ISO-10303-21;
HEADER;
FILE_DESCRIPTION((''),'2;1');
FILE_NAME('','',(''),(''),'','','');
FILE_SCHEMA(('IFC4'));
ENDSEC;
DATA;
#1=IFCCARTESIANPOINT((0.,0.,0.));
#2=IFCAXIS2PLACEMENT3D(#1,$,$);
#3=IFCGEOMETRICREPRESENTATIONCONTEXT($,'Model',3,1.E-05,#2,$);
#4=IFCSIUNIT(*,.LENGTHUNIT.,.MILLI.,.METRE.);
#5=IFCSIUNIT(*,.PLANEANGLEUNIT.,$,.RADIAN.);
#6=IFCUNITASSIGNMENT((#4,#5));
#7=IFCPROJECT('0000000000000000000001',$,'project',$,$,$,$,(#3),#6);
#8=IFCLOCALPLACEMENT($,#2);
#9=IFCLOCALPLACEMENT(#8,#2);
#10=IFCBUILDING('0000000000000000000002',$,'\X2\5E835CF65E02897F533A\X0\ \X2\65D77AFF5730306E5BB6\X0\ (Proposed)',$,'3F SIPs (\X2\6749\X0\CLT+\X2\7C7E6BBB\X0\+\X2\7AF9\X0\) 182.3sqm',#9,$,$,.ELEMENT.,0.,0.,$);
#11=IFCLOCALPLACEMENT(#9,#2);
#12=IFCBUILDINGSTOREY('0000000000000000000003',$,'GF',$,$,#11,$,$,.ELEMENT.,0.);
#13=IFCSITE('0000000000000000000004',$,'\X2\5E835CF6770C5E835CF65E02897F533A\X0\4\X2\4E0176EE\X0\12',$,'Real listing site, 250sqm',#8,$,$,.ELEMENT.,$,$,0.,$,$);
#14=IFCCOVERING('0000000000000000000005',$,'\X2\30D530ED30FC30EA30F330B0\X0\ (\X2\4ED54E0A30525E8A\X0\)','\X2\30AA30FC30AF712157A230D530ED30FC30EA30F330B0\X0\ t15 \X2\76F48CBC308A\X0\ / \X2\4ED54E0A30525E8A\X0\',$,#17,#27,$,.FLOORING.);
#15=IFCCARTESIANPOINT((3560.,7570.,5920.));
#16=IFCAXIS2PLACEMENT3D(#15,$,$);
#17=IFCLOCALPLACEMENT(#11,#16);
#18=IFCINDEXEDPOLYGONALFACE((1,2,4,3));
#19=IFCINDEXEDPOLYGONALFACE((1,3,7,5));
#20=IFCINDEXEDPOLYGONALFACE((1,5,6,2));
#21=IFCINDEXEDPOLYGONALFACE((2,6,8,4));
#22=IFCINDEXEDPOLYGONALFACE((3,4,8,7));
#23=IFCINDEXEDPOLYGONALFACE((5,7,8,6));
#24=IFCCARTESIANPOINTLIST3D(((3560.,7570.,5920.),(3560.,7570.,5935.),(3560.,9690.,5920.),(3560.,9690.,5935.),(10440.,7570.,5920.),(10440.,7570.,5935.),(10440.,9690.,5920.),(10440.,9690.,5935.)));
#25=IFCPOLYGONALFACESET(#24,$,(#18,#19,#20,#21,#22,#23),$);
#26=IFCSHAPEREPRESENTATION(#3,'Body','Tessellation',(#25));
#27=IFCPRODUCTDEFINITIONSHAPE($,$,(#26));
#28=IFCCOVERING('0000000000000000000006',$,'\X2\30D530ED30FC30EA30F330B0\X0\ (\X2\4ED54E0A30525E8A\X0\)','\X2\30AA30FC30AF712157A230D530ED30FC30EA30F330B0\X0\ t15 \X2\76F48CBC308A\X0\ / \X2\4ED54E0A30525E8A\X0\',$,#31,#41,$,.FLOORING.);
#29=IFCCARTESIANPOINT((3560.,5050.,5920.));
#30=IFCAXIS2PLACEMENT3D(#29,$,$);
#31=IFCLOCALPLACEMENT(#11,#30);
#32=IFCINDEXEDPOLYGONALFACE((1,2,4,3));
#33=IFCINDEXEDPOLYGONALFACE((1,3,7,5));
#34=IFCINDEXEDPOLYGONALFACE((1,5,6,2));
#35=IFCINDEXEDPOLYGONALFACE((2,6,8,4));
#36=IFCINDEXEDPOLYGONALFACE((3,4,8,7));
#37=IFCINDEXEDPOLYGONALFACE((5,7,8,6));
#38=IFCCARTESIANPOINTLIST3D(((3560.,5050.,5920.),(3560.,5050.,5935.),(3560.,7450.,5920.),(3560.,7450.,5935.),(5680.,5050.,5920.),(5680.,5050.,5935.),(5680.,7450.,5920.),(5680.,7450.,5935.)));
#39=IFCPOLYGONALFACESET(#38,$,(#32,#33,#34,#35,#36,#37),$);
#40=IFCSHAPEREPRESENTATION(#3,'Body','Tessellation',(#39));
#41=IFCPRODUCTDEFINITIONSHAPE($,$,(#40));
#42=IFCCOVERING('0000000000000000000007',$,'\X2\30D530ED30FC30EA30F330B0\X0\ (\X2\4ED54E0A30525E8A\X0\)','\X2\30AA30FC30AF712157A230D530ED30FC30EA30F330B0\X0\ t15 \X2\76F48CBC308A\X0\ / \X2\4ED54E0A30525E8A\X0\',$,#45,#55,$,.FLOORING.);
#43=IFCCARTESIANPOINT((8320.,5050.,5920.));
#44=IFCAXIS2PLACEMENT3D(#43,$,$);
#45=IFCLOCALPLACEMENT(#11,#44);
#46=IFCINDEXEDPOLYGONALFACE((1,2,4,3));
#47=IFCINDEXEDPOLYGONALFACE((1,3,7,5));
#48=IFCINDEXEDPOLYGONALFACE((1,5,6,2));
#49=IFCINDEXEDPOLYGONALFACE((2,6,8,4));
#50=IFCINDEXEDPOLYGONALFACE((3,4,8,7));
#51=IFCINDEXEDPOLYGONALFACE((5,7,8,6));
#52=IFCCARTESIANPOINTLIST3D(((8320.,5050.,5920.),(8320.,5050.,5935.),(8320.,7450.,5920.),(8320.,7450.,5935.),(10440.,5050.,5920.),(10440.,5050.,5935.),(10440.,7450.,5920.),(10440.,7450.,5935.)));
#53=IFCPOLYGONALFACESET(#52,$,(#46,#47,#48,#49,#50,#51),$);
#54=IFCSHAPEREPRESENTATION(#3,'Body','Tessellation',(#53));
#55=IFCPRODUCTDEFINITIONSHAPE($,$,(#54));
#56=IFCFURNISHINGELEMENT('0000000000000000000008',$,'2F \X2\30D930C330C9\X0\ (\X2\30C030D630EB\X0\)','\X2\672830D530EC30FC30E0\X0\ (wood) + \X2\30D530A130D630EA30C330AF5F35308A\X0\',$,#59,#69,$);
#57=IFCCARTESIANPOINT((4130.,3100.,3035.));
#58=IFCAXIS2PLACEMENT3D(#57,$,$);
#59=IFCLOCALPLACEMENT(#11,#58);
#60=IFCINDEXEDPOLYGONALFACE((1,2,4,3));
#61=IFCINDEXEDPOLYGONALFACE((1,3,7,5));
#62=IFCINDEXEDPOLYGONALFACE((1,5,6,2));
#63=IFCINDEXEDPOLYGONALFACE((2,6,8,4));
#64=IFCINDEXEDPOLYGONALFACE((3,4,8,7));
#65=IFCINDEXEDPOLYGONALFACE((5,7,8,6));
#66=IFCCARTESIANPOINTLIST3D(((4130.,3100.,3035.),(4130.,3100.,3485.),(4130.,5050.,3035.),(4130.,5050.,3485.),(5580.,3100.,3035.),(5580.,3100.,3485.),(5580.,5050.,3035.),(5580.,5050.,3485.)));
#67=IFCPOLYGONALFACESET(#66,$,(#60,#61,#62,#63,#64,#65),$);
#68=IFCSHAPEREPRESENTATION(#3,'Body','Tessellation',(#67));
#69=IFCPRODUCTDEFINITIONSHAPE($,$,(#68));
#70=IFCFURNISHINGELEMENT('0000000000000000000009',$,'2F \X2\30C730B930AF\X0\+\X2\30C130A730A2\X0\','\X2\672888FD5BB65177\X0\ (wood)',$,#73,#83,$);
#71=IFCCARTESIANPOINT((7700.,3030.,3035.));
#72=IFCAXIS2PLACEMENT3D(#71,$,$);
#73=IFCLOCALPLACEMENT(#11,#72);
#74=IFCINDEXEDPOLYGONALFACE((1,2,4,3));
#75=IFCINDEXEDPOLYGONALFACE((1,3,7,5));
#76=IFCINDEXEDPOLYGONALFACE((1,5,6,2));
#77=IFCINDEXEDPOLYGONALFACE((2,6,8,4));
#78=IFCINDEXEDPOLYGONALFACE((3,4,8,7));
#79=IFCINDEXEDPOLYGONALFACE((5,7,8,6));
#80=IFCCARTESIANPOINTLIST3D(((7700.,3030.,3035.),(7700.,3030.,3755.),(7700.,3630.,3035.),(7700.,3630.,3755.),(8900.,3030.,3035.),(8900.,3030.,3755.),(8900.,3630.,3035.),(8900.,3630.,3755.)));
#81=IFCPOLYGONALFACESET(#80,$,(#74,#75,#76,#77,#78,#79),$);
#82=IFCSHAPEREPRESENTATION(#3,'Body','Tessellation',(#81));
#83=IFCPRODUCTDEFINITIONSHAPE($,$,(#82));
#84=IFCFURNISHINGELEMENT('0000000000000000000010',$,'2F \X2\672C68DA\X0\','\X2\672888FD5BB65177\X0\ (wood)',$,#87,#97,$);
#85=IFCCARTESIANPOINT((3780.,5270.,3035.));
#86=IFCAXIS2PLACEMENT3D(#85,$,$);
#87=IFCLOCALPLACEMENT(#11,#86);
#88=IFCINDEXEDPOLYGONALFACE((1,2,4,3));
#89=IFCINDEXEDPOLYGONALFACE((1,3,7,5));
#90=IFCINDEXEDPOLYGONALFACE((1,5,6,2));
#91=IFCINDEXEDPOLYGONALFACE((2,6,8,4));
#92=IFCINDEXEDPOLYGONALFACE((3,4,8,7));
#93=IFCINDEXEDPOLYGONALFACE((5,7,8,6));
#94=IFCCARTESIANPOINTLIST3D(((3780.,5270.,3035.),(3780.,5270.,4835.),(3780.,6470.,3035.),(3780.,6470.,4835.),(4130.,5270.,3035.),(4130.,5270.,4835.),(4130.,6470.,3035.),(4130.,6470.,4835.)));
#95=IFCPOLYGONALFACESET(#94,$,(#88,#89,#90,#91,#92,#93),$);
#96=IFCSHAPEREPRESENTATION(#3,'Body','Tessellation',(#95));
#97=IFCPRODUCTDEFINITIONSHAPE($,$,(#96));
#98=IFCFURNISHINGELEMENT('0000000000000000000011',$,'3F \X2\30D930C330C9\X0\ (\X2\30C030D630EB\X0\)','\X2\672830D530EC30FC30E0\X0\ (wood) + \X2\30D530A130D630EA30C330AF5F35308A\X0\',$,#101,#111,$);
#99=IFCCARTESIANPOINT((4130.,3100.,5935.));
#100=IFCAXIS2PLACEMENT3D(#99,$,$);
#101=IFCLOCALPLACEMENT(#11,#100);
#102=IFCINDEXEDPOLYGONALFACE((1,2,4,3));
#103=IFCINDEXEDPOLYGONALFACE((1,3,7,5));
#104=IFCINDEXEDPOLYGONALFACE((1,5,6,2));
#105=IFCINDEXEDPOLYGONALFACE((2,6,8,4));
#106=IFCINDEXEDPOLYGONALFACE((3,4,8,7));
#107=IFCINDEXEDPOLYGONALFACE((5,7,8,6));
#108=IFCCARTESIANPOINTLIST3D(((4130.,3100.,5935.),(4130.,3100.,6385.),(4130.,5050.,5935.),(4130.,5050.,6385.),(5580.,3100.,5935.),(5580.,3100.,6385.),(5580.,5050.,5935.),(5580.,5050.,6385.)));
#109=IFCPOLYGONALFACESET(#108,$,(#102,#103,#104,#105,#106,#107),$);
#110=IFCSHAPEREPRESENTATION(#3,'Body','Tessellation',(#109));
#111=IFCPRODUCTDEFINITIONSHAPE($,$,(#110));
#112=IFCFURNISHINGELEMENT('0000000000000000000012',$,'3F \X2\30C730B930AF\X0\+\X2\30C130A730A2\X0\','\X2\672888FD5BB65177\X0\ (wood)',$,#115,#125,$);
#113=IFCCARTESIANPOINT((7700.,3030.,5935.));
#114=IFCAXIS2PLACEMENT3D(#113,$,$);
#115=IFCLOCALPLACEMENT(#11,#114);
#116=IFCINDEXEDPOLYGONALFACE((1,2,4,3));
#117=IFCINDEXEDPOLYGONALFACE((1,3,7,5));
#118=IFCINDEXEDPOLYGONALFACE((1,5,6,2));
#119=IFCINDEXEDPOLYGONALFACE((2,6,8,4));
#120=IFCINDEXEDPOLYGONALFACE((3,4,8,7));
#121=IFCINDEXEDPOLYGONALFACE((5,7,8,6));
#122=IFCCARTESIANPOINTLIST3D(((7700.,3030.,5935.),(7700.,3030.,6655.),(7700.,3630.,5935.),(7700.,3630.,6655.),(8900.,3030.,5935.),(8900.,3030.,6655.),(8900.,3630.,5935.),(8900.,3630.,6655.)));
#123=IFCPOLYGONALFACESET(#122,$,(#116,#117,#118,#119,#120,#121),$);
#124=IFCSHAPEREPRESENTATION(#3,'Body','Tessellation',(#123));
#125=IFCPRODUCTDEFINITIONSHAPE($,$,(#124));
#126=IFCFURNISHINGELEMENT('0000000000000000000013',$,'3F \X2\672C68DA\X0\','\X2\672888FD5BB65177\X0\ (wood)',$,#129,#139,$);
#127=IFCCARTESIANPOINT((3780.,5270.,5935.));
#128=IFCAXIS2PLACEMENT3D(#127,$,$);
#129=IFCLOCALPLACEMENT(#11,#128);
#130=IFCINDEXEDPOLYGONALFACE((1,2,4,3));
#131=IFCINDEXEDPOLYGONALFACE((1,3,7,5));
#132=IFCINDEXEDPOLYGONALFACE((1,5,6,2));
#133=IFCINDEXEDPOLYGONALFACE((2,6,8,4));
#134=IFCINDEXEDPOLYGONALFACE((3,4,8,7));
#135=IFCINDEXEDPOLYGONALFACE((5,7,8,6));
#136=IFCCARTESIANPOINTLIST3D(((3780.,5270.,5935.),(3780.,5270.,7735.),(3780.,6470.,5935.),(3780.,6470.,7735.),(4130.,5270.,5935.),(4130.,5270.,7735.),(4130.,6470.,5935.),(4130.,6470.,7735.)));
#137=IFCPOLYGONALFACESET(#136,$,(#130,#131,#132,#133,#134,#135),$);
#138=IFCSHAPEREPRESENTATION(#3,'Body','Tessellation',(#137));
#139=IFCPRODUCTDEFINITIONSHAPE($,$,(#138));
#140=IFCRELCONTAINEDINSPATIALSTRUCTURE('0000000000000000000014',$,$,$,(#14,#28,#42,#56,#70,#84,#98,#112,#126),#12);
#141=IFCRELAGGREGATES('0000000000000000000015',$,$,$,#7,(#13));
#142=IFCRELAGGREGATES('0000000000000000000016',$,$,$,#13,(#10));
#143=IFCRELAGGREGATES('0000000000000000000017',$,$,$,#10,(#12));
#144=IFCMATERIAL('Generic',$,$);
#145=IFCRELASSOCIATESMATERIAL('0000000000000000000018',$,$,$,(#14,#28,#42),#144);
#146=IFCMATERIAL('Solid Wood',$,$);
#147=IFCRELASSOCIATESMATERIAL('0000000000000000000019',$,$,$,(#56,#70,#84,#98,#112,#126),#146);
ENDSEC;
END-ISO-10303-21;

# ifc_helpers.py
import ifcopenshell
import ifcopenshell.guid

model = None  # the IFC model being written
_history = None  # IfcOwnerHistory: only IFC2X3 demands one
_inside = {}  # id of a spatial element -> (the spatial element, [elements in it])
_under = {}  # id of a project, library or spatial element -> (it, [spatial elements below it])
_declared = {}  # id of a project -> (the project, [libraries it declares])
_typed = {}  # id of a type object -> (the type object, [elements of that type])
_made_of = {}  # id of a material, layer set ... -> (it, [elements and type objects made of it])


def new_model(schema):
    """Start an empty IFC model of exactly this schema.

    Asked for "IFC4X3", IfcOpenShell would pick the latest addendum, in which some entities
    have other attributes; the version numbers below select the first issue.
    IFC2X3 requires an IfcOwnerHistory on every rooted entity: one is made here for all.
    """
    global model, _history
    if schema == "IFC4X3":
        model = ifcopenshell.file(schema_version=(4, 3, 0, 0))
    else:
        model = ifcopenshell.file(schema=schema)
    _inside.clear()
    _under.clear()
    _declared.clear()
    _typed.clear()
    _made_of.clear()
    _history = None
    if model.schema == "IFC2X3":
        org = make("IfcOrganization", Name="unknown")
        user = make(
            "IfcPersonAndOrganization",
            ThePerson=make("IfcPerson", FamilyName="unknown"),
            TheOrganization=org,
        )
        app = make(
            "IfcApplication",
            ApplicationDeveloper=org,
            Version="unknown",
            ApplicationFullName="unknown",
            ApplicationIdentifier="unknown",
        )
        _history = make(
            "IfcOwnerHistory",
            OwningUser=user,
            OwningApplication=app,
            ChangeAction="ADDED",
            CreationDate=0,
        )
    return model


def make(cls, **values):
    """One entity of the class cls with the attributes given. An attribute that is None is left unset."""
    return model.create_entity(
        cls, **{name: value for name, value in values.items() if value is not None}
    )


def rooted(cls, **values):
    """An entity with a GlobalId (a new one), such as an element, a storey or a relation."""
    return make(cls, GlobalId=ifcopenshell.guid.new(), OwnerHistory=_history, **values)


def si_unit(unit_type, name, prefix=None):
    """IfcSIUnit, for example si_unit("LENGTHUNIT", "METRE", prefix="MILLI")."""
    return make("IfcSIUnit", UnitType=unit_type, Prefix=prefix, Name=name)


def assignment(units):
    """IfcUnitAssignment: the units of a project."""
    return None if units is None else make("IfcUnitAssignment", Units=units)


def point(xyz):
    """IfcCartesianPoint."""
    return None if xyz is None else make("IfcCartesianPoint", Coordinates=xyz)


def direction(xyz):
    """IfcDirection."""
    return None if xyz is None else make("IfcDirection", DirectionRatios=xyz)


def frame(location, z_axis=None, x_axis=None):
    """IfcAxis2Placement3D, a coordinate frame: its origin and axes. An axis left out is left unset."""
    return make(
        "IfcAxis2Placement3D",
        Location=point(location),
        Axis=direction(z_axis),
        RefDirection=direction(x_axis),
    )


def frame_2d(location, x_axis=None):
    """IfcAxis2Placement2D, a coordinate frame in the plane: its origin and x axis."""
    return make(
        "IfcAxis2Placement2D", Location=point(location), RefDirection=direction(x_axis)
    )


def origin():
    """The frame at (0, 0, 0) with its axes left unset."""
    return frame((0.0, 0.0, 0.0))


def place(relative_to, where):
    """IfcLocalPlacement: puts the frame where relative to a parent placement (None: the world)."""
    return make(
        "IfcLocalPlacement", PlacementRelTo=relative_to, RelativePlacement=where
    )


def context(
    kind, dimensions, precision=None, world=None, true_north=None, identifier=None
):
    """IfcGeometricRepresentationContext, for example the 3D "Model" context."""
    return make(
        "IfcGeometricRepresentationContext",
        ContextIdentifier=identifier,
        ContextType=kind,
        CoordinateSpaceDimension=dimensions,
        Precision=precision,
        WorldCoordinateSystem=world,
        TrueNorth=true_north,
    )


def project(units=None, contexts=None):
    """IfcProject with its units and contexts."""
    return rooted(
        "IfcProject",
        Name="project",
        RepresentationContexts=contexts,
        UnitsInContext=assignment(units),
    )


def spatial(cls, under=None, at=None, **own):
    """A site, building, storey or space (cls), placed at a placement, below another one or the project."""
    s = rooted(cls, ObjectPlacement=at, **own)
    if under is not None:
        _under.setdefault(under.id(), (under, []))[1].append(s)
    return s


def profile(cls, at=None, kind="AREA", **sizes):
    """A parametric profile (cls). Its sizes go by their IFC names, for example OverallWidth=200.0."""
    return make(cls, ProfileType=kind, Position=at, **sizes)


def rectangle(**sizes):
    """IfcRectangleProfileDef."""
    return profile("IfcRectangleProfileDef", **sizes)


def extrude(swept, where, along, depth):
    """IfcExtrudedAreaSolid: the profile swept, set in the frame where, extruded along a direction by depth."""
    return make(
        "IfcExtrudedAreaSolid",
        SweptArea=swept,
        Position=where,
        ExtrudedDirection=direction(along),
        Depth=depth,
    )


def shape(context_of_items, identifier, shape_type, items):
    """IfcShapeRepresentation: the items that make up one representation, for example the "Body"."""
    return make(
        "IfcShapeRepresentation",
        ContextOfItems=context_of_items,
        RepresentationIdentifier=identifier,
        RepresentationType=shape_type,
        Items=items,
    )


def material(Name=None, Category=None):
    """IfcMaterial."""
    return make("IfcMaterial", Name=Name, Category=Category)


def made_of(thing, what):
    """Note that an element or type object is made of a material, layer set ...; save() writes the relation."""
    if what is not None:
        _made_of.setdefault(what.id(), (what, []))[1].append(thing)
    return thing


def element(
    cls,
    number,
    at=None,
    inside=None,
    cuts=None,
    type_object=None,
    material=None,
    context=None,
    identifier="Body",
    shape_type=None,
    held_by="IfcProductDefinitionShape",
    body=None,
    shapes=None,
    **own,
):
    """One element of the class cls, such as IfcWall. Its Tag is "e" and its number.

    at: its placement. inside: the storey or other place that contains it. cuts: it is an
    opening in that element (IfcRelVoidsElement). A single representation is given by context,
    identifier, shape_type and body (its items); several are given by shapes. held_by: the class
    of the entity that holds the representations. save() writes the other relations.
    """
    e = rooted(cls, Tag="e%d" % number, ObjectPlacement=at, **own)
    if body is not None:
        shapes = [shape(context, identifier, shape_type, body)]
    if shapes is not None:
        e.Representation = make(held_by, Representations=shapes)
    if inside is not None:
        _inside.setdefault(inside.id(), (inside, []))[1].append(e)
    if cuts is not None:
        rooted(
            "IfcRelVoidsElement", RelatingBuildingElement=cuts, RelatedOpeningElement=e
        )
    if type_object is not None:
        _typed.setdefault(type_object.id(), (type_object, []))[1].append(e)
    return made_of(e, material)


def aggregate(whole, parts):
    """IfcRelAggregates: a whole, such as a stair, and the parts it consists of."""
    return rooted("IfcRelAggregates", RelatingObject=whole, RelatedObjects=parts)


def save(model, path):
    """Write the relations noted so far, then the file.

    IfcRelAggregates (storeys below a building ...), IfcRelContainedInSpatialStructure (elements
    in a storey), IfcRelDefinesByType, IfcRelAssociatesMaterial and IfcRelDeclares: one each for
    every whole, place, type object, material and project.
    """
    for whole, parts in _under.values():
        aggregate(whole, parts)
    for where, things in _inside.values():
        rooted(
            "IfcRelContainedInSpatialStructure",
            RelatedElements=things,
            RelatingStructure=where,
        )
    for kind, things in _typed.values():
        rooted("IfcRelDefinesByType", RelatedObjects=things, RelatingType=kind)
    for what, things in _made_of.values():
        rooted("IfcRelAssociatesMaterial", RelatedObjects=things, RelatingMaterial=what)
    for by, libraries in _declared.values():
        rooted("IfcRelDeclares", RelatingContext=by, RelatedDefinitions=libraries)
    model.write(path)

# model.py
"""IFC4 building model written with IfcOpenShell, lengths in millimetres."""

from ifc_helpers import new_model, si_unit, frame, frame_2d, origin, place, context, project, spatial, rectangle, extrude, material, element, save


model = new_model("IFC4")

# Units and contexts
model_context = context("Model", 3, precision=1e-05, world=origin())
ifc_project = project(units=[si_unit("LENGTHUNIT", "METRE", prefix="MILLI"), si_unit("PLANEANGLEUNIT", "RADIAN")], contexts=[model_context])

# Site, building, storey
site_placement = place(None, origin())
site = spatial("IfcSite", under=ifc_project, at=site_placement, Name="広島県広島市西区4丁目12", ObjectType="Real listing site, 250sqm", CompositionType="ELEMENT", RefElevation=0.0)
building_placement = place(site_placement, origin())
building = spatial("IfcBuilding", under=site, at=building_placement, Name="広島市西区 旗竿地の家 (Proposed)", ObjectType="3F SIPs (杉CLT+籾殻+竹) 182.3sqm", CompositionType="ELEMENT", ElevationOfRefHeight=0.0, ElevationOfTerrain=0.0)
storey_placement = place(building_placement, origin())
storey = spatial("IfcBuildingStorey", under=building, at=storey_placement, Name="GF", CompositionType="ELEMENT", Elevation=0.0)

# Shared definitions
ifc_material_1 = material(Name="Solid Wood")

# Shared definitions
ifc_material_2 = material(Name="Generic")

# Coverings
covering_1_placement = place(storey_placement, frame((3560.0, 7570.0, 5920.0)))
element("IfcCovering", 1, at=covering_1_placement, inside=storey, material=ifc_material_2, Name="フローリング (仕上げ床)", Description="オーク無垢フローリング t15 直貼り / 仕上げ床", PredefinedType="FLOORING", context=model_context, shape_type="SweptSolid", body=[
    extrude(rectangle(XDim=6880.0, YDim=2120.0, at=frame_2d((3440.0, 1060.0))), frame((3560.0, 7570.0, 5920.0)), (0.0, 0.0, 1.0), 15.0),
])
covering_2_placement = place(storey_placement, frame((3560.0, 5050.0, 5920.0)))
element("IfcCovering", 2, at=covering_2_placement, inside=storey, material=ifc_material_2, Name="フローリング (仕上げ床)", Description="オーク無垢フローリング t15 直貼り / 仕上げ床", PredefinedType="FLOORING", context=model_context, shape_type="SweptSolid", body=[
    extrude(rectangle(XDim=2120.0, YDim=2400.0, at=frame_2d((1060.0, 1200.0))), frame((3560.0, 5050.0, 5920.0)), (0.0, 0.0, 1.0), 15.0),
])
covering_3_placement = place(storey_placement, frame((8320.0, 5050.0, 5920.0)))
element("IfcCovering", 3, at=covering_3_placement, inside=storey, material=ifc_material_2, Name="フローリング (仕上げ床)", Description="オーク無垢フローリング t15 直貼り / 仕上げ床", PredefinedType="FLOORING", context=model_context, shape_type="SweptSolid", body=[
    extrude(rectangle(XDim=2120.0, YDim=2400.0, at=frame_2d((1060.0, 1200.0))), frame((8320.0, 5050.0, 5920.0)), (0.0, 0.0, 1.0), 15.0),
])

# Furnishing elements
furnishing_1_placement = place(storey_placement, frame((4130.0, 3100.0, 3035.0)))
element("IfcFurnishingElement", 4, at=furnishing_1_placement, inside=storey, material=ifc_material_1, Name="2F ベッド (ダブル)", Description="木フレーム (wood) + ファブリック張り", context=model_context, shape_type="SweptSolid", body=[
    extrude(rectangle(XDim=1450.0, YDim=1950.0, at=frame_2d((725.0, 975.0))), frame((4130.0, 3100.0, 3035.0)), (0.0, 0.0, 1.0), 450.0),
])
furnishing_2_placement = place(storey_placement, frame((7700.0, 3030.0, 3035.0)))
element("IfcFurnishingElement", 5, at=furnishing_2_placement, inside=storey, material=ifc_material_1, Name="2F デスク+チェア", Description="木製家具 (wood)", context=model_context, shape_type="SweptSolid", body=[
    extrude(rectangle(XDim=1200.0, YDim=600.0, at=frame_2d((600.0, 300.0))), frame((7700.0, 3030.0, 3035.0)), (0.0, 0.0, 1.0), 720.0),
])
furnishing_3_placement = place(storey_placement, frame((3780.0, 5270.0, 3035.0)))
element("IfcFurnishingElement", 6, at=furnishing_3_placement, inside=storey, material=ifc_material_1, Name="2F 本棚", Description="木製家具 (wood)", context=model_context, shape_type="SweptSolid", body=[
    extrude(rectangle(XDim=350.0, YDim=1200.0, at=frame_2d((175.0, 600.0))), frame((3780.0, 5270.0, 3035.0)), (0.0, 0.0, 1.0), 1800.0),
])
furnishing_4_placement = place(storey_placement, frame((4130.0, 3100.0, 5935.0)))
element("IfcFurnishingElement", 7, at=furnishing_4_placement, inside=storey, material=ifc_material_1, Name="3F ベッド (ダブル)", Description="木フレーム (wood) + ファブリック張り", context=model_context, shape_type="SweptSolid", body=[
    extrude(rectangle(XDim=1450.0, YDim=1950.0, at=frame_2d((725.0, 975.0))), frame((4130.0, 3100.0, 5935.0)), (0.0, 0.0, 1.0), 450.0),
])
furnishing_5_placement = place(storey_placement, frame((7700.0, 3030.0, 5935.0)))
element("IfcFurnishingElement", 8, at=furnishing_5_placement, inside=storey, material=ifc_material_1, Name="3F デスク+チェア", Description="木製家具 (wood)", context=model_context, shape_type="SweptSolid", body=[
    extrude(rectangle(XDim=1200.0, YDim=600.0, at=frame_2d((600.0, 300.0))), frame((7700.0, 3030.0, 5935.0)), (0.0, 0.0, 1.0), 720.0),
])
furnishing_6_placement = place(storey_placement, frame((3780.0, 5270.0, 5935.0)))
element("IfcFurnishingElement", 9, at=furnishing_6_placement, inside=storey, material=ifc_material_1, Name="3F 本棚", Description="木製家具 (wood)", context=model_context, shape_type="SweptSolid", body=[
    extrude(rectangle(XDim=350.0, YDim=1200.0, at=frame_2d((175.0, 600.0))), frame((3780.0, 5270.0, 5935.0)), (0.0, 0.0, 1.0), 1800.0),
])

save(model, "model.ifc")
